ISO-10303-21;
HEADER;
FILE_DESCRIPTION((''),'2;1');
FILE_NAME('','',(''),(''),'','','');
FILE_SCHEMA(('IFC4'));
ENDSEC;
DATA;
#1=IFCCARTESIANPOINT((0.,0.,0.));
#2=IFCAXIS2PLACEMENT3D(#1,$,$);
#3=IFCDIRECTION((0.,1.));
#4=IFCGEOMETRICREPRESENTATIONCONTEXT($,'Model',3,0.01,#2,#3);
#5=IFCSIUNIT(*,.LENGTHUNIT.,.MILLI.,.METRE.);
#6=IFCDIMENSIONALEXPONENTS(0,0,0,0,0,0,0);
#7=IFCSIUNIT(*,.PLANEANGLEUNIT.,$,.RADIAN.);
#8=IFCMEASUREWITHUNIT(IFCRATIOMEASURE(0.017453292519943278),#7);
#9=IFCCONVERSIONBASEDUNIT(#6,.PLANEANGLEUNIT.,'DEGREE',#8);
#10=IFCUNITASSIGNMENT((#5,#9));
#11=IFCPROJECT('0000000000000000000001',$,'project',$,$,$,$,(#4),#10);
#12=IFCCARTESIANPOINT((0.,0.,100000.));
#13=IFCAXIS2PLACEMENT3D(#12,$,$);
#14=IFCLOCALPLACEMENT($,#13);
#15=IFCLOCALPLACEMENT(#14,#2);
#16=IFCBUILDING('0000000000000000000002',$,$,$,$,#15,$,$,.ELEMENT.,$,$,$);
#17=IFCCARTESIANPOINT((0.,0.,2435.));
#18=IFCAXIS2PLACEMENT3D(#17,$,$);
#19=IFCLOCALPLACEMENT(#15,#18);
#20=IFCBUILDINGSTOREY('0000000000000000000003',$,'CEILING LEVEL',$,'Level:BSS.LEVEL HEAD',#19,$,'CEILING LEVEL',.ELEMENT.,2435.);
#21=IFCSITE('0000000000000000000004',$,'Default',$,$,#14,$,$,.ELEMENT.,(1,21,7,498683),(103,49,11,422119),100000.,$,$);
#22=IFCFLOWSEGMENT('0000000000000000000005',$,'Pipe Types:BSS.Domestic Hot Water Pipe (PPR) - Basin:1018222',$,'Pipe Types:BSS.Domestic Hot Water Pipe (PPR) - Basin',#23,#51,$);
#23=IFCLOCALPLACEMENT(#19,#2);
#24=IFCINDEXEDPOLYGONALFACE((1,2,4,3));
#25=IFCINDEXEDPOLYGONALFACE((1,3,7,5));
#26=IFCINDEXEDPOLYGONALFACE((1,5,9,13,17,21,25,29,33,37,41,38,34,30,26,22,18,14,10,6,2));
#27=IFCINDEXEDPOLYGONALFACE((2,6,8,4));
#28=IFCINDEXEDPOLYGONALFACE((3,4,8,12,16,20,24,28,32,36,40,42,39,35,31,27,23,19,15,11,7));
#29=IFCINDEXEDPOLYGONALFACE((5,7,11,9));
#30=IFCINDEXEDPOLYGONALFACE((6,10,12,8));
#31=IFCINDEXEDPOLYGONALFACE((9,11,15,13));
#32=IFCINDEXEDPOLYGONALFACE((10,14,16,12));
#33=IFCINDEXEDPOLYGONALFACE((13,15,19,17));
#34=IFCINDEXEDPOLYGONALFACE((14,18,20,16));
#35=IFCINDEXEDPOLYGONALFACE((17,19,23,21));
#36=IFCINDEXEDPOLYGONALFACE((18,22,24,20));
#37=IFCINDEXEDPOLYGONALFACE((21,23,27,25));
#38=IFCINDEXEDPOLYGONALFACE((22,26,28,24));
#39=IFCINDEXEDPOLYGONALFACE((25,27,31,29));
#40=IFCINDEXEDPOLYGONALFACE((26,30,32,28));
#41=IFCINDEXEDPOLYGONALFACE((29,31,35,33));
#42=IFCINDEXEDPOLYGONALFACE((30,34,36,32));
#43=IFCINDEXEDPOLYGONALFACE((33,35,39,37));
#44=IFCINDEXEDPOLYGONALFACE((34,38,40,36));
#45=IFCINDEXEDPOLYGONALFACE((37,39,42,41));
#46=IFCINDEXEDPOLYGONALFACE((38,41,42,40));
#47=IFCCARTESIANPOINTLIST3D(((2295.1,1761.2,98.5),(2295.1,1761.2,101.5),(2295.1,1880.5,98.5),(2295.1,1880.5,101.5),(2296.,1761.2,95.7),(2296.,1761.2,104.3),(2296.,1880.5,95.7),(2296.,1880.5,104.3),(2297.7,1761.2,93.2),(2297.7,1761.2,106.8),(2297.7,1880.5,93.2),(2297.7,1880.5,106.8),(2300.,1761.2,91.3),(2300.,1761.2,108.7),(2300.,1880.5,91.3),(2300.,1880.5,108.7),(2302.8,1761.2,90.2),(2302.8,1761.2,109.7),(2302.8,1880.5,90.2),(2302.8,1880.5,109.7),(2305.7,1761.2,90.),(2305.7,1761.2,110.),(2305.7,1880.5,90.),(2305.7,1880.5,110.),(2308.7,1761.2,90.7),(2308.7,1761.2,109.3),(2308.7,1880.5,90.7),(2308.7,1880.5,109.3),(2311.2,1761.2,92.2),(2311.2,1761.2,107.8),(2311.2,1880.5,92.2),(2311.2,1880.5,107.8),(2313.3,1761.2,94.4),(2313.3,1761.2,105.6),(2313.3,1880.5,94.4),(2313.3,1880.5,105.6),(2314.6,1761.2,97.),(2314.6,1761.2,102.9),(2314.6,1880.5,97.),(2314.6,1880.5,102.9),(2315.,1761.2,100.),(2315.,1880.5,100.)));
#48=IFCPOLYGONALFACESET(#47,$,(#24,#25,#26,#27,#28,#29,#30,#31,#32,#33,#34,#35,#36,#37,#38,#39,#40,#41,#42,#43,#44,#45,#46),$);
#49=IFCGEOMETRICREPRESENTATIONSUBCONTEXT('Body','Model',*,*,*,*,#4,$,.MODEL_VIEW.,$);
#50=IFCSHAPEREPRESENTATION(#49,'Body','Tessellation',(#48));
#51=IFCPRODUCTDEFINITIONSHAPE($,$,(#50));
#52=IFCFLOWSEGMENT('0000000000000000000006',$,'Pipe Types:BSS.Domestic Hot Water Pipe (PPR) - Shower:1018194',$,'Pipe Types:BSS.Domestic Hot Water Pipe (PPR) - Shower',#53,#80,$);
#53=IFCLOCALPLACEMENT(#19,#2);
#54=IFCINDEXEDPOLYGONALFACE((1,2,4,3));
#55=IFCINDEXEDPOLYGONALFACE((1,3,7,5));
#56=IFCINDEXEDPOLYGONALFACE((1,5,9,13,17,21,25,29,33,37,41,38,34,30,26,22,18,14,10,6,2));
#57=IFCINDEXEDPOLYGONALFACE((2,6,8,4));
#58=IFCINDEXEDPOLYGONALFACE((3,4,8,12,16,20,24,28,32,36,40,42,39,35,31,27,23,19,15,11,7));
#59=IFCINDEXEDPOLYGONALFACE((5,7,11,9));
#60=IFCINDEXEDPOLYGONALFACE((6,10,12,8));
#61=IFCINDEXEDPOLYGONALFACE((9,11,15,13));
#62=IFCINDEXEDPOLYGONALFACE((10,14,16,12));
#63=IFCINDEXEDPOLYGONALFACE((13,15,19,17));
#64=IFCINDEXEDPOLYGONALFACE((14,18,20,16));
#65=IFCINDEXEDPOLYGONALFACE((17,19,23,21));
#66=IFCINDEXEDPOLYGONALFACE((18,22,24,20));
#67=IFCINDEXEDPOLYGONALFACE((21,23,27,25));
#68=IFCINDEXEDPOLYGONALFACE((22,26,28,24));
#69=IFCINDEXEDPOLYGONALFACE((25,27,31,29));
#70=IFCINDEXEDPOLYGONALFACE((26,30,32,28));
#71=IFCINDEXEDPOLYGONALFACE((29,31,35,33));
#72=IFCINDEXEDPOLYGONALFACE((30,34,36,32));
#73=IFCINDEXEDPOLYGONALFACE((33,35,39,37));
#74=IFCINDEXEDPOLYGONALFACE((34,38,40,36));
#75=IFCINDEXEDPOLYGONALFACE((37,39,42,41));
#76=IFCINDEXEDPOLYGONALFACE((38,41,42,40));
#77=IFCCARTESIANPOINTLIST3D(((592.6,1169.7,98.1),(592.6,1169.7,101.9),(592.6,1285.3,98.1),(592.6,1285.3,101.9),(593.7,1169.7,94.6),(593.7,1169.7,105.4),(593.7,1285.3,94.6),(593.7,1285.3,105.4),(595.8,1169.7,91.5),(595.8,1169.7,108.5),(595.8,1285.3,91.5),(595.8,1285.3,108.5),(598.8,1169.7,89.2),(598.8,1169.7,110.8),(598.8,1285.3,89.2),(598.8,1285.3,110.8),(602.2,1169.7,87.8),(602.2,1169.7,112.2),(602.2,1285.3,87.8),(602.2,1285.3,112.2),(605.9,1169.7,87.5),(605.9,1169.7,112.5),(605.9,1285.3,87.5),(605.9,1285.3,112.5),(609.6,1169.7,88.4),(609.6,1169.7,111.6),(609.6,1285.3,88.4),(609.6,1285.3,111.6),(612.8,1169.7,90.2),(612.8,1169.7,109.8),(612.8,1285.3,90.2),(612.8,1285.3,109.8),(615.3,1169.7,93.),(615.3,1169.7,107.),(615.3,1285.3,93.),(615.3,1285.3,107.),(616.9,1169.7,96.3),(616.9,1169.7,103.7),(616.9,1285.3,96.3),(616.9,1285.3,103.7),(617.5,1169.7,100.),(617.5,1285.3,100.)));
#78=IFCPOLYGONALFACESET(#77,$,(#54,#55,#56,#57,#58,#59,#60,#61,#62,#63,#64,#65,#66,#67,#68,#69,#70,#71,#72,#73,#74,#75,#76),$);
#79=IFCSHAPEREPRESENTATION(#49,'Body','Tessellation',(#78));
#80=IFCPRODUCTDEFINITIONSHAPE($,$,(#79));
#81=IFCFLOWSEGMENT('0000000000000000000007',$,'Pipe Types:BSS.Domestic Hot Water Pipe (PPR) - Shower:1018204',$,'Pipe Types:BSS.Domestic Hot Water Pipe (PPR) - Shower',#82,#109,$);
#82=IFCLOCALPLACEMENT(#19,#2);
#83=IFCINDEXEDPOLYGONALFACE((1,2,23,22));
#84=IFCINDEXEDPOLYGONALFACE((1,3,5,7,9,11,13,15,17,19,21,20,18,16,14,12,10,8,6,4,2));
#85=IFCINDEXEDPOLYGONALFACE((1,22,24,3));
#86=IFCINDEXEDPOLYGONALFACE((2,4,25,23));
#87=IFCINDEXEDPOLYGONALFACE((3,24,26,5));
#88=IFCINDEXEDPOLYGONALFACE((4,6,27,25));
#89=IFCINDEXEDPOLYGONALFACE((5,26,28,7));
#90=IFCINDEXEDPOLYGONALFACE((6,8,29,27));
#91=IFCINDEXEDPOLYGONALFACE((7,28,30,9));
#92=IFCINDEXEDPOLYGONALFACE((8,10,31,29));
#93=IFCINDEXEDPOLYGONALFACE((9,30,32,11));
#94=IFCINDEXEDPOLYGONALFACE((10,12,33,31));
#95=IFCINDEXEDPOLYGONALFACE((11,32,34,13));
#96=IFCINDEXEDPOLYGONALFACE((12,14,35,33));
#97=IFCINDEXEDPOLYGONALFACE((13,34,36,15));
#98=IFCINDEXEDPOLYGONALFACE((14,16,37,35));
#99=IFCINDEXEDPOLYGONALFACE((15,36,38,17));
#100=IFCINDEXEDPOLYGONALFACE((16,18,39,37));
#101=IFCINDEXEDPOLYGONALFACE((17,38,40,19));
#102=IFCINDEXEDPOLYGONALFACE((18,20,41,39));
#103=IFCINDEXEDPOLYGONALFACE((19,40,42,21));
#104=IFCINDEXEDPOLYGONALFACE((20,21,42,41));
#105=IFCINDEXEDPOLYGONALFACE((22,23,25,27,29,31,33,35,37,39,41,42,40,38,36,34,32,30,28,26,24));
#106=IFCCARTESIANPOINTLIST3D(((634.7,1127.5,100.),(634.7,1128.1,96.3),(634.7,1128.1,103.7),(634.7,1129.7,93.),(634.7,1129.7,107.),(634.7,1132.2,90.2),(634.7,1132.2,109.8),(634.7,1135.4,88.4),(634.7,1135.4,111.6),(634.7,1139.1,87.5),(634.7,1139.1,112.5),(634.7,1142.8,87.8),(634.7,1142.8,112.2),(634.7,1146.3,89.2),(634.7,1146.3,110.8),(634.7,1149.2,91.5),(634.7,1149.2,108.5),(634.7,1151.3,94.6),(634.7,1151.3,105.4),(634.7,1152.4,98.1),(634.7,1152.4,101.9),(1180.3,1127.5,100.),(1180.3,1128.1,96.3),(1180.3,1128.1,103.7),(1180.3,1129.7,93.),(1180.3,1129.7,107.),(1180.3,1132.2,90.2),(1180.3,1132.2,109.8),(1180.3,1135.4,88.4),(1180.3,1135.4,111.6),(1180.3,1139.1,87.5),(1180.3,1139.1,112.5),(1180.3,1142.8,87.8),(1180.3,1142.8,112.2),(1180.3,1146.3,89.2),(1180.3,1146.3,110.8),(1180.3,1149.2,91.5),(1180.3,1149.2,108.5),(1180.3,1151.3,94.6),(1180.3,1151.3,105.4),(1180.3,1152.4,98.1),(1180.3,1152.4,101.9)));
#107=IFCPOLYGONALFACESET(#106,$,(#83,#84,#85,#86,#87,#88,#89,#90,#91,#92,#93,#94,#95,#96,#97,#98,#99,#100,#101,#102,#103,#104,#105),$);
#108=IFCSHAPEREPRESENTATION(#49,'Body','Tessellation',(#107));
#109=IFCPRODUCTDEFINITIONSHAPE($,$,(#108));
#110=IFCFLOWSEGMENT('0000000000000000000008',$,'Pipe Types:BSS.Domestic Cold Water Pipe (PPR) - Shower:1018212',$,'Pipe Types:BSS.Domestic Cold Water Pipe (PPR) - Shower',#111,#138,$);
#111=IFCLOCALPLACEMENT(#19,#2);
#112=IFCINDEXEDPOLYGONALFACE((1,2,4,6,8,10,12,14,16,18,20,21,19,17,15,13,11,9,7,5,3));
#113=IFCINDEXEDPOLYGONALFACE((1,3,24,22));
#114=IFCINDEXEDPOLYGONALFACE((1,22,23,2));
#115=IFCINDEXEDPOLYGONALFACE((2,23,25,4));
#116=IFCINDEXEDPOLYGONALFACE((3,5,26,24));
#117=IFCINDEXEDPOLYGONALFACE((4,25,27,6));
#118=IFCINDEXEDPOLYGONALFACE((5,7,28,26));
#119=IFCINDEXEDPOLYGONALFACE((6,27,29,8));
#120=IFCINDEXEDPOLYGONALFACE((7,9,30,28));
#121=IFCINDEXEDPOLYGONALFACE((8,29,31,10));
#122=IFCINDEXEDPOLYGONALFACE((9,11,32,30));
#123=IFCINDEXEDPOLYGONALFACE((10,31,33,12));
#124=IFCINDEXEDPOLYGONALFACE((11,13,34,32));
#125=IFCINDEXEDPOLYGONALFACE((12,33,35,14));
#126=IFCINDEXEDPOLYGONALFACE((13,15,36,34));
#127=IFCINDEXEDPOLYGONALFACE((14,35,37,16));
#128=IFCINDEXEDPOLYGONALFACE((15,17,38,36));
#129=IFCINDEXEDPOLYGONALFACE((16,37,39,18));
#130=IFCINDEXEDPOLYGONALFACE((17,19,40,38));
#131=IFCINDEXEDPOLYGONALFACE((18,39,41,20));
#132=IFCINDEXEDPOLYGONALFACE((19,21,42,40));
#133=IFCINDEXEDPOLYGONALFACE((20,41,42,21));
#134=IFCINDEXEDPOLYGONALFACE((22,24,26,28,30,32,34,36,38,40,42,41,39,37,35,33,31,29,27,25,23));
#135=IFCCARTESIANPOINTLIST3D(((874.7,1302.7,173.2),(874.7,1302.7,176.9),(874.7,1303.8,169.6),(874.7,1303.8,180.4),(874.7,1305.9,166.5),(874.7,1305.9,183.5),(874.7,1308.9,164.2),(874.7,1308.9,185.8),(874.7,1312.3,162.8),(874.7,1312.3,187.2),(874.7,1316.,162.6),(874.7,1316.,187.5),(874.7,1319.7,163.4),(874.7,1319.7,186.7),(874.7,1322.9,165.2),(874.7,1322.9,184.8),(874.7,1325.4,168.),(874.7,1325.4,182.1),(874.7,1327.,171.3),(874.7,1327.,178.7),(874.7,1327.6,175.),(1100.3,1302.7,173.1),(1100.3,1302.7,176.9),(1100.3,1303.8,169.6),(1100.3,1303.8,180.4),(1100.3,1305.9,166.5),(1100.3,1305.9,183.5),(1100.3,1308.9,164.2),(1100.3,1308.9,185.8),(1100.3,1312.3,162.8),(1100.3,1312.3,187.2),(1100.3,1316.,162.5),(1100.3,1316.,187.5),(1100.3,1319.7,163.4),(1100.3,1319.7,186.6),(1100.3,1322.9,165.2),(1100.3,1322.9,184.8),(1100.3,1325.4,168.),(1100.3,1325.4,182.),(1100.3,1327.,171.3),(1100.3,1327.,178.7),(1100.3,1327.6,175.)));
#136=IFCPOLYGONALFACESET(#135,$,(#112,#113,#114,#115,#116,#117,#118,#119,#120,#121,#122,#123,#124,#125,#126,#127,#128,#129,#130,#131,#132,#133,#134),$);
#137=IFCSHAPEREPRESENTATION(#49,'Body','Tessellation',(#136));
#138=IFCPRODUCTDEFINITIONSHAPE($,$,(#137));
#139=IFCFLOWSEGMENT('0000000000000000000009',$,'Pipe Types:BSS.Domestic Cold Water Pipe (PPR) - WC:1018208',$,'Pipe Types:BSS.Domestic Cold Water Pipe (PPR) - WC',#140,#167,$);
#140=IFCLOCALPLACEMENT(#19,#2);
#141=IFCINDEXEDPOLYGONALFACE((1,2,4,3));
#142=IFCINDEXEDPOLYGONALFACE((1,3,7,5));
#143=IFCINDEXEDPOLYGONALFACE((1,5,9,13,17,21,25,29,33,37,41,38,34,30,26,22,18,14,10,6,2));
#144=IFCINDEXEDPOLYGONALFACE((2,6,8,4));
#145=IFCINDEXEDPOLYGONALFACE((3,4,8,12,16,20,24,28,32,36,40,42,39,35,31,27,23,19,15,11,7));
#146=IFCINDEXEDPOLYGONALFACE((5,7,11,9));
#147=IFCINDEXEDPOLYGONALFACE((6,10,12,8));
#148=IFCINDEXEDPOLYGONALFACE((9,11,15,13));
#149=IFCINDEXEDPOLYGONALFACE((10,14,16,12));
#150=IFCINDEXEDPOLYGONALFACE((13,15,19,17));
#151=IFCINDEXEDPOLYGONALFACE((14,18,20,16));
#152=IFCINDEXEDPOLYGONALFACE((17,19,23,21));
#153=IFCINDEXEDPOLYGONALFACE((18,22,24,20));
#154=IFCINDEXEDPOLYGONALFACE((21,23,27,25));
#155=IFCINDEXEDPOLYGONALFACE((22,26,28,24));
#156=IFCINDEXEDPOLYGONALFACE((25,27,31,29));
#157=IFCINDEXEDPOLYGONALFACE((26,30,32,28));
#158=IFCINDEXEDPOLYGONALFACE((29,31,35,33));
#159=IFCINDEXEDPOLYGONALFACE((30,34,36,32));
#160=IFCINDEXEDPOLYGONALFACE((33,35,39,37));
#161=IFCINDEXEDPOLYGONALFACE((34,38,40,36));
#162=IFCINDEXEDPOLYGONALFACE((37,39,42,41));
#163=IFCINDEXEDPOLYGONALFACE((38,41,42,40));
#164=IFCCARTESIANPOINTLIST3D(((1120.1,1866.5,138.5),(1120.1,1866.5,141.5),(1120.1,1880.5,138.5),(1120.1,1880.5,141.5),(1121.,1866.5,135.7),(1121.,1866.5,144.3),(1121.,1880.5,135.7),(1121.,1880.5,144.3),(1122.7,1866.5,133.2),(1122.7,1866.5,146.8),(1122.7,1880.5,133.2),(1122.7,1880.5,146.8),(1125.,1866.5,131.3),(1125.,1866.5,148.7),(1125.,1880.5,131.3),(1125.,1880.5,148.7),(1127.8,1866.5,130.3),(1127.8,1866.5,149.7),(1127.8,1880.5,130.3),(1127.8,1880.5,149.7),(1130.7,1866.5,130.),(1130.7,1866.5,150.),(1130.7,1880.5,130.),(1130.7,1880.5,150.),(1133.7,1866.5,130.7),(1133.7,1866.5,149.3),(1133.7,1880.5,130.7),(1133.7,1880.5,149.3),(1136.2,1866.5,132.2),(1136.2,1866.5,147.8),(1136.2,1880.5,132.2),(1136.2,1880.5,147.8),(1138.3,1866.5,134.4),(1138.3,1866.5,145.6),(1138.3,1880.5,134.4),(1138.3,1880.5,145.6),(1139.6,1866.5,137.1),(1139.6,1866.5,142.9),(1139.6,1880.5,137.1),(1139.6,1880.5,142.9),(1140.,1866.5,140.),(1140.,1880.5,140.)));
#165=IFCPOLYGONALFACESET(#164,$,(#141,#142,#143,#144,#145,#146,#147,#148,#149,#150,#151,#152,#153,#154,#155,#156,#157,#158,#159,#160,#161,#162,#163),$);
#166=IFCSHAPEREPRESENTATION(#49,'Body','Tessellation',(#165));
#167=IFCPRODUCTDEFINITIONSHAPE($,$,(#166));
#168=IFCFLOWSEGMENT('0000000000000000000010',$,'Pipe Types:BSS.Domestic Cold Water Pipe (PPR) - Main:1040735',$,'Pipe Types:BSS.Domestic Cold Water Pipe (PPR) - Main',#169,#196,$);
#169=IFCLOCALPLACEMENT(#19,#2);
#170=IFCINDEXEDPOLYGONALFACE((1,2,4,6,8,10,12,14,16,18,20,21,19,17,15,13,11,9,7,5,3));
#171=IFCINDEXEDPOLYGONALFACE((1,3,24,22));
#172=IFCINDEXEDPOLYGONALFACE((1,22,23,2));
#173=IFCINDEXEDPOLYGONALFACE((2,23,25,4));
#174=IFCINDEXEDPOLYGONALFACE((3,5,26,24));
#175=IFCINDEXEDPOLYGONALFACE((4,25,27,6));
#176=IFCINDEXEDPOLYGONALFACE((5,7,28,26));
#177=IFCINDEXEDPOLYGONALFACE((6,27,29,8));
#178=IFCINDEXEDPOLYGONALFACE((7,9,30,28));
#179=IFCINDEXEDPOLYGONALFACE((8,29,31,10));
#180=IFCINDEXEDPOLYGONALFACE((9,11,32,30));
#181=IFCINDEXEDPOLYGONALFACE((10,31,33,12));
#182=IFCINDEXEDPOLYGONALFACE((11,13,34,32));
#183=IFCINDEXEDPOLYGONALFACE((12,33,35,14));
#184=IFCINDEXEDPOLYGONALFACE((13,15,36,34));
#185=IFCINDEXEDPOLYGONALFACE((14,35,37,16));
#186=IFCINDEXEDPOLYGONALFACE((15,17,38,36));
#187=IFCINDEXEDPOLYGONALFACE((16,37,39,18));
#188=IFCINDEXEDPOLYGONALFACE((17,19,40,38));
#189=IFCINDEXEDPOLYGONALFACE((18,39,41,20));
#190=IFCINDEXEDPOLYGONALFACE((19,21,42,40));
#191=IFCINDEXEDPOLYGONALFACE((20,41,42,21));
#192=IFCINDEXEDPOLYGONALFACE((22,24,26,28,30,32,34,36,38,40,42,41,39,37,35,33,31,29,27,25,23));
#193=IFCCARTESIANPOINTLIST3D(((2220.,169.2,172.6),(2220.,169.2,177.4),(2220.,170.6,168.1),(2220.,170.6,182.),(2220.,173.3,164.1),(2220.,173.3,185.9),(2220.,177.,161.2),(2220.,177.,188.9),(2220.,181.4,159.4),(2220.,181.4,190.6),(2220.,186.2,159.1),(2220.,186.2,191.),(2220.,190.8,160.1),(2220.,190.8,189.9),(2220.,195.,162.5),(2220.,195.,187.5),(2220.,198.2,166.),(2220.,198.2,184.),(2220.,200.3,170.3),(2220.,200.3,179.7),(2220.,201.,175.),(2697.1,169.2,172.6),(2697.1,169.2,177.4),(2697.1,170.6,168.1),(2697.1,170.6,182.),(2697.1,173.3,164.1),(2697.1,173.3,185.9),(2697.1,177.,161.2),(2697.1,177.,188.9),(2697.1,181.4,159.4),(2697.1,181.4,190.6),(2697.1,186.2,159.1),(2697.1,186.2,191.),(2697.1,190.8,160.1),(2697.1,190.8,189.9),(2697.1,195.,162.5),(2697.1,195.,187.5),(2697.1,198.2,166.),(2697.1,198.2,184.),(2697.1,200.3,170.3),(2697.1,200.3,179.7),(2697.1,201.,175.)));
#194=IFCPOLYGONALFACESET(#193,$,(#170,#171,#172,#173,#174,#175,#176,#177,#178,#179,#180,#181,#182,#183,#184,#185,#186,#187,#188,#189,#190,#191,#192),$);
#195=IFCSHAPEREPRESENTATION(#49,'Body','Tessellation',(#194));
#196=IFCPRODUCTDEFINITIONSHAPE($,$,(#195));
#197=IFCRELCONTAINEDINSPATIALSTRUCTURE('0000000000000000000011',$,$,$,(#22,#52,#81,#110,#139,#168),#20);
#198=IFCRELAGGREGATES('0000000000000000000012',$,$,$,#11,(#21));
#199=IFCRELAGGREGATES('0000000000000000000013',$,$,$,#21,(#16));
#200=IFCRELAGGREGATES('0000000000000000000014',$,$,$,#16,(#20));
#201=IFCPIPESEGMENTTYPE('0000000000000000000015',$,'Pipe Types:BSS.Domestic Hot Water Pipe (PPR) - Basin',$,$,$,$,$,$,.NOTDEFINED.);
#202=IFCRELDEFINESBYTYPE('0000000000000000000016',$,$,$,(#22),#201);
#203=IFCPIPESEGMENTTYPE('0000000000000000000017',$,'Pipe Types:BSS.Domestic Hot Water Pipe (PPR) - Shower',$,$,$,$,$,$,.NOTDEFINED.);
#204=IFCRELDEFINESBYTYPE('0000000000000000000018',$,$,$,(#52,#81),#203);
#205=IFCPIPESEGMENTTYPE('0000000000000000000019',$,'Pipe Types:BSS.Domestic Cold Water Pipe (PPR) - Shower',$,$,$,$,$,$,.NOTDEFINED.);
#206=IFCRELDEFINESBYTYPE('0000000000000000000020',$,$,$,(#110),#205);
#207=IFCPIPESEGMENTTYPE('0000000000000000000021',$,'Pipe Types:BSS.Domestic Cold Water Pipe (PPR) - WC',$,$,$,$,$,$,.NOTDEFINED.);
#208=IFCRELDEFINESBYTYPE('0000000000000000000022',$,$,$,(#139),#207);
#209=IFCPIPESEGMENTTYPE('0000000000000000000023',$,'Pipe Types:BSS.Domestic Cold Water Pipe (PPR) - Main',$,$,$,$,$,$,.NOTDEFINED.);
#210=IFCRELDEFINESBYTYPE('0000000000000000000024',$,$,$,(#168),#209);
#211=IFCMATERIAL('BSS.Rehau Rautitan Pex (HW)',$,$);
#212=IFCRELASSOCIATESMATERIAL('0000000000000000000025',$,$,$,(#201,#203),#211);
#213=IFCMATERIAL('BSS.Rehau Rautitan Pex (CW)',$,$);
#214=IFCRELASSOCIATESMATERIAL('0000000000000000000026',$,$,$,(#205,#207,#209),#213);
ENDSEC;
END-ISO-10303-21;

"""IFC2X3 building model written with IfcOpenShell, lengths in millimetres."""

from ifc_helpers import new_model, entity, si_unit, converted_unit, direction, frame, frame_2d, origin, origin_2d_with_axis, place, context, subcontext, project, spatial, circle, extrude, material, type_object, element, save


model = new_model("IFC2X3")

# Units and contexts
model_context = context("Model", 3, precision=0.01, world=origin(), true_north=direction((0.0, 1.0)))
body_context = subcontext(model_context, "Body", "Model", "MODEL_VIEW")
ifc_project = project(units=[si_unit("LENGTHUNIT", "METRE", prefix="MILLI"), converted_unit("PLANEANGLEUNIT", "DEGREE", entity("IfcRatioMeasure", 0.017453292519943278), si_unit("PLANEANGLEUNIT", "RADIAN"), dimensions=[0, 0, 0, 0, 0, 0, 0])], contexts=[model_context])

# Site, building, storey
site_placement = place(None, frame((0.0, 0.0, 100000.0)))
site = spatial("IfcSite", under=ifc_project, at=site_placement, Name="Default", CompositionType="ELEMENT", RefLatitude=(1, 21, 7, 498683), RefLongitude=(103, 49, 11, 422119), RefElevation=100000.0)
building_placement = place(site_placement, origin())
building = spatial("IfcBuilding", under=site, at=building_placement, CompositionType="ELEMENT")
storey_placement = place(building_placement, frame((0.0, 0.0, 2435.0)))
storey = spatial("IfcBuildingStorey", under=building, at=storey_placement, Name="CEILING LEVEL", ObjectType="Level:BSS.LEVEL HEAD", LongName="CEILING LEVEL", CompositionType="ELEMENT", Elevation=2435.0)

# Flow segments
ifc_material_1 = material(Name="BSS.Rehau Rautitan Pex (HW)")
pipe_segment_type_1 = type_object("IfcPipeSegmentType", Name="Pipe Types:BSS.Domestic Hot Water Pipe (PPR) - Basin", PredefinedType="NOTDEFINED", material=ifc_material_1)
flow_segment_1_placement = place(storey_placement, origin())
element("IfcFlowSegment", 1, at=flow_segment_1_placement, inside=storey, type_object=pipe_segment_type_1, Name="Pipe Types:BSS.Domestic Hot Water Pipe (PPR) - Basin:1018222", ObjectType="Pipe Types:BSS.Domestic Hot Water Pipe (PPR) - Basin", context=body_context, shape_type="SweptSolid", body=[
    extrude(circle(Radius=10.0, at=frame_2d((0.0, 0.0), x_axis=(1.0, 0.0))), frame((2305.0, 1880.5, 100.0), z_axis=(0.00001, -1.0, 0.0), x_axis=(1.0, 0.00001, 0.0)), (0.0, 0.0, 1.0), 119.3),
])
pipe_segment_type_2 = type_object("IfcPipeSegmentType", Name="Pipe Types:BSS.Domestic Hot Water Pipe (PPR) - Shower", PredefinedType="NOTDEFINED", material=ifc_material_1)
flow_segment_2_placement = place(storey_placement, origin())
element("IfcFlowSegment", 2, at=flow_segment_2_placement, inside=storey, type_object=pipe_segment_type_2, Name="Pipe Types:BSS.Domestic Hot Water Pipe (PPR) - Shower:1018194", ObjectType="Pipe Types:BSS.Domestic Hot Water Pipe (PPR) - Shower", context=body_context, shape_type="SweptSolid", body=[
    extrude(circle(Radius=12.5, at=frame_2d((0.0, 0.0), x_axis=(1.0, 0.0))), frame((605.0, 1285.3, 100.0), z_axis=(0.0, -1.0, 0.000036), x_axis=(1.0, 0.0, 0.0)), (0.0, 0.0, 1.0), 115.6),
])
flow_segment_3_placement = place(storey_placement, origin())
element("IfcFlowSegment", 3, at=flow_segment_3_placement, inside=storey, type_object=pipe_segment_type_2, Name="Pipe Types:BSS.Domestic Hot Water Pipe (PPR) - Shower:1018204", ObjectType="Pipe Types:BSS.Domestic Hot Water Pipe (PPR) - Shower", context=body_context, shape_type="SweptSolid", body=[
    extrude(circle(Radius=12.5, at=frame_2d((0.0, 0.0), x_axis=(1.0, 0.0))), frame((634.7, 1140.0, 100.0), z_axis=(1.0, 0.0, -0.00001), x_axis=(0.0, -1.0, 0.0)), (0.0, 0.0, 1.0), 545.6),
])
ifc_material_2 = material(Name="BSS.Rehau Rautitan Pex (CW)")
pipe_segment_type_3 = type_object("IfcPipeSegmentType", Name="Pipe Types:BSS.Domestic Cold Water Pipe (PPR) - Shower", PredefinedType="NOTDEFINED", material=ifc_material_2)
flow_segment_4_placement = place(storey_placement, origin())
element("IfcFlowSegment", 4, at=flow_segment_4_placement, inside=storey, type_object=pipe_segment_type_3, Name="Pipe Types:BSS.Domestic Cold Water Pipe (PPR) - Shower:1018212", ObjectType="Pipe Types:BSS.Domestic Cold Water Pipe (PPR) - Shower", context=body_context, shape_type="SweptSolid", body=[
    extrude(circle(Radius=12.5, at=origin_2d_with_axis()), frame((874.7, 1315.1, 175.0), z_axis=(1.0, 0.000003, -0.000078), x_axis=(-0.000003, 1.0, 0.0)), (0.0, 0.0, 1.0), 225.6),
])
pipe_segment_type_4 = type_object("IfcPipeSegmentType", Name="Pipe Types:BSS.Domestic Cold Water Pipe (PPR) - WC", PredefinedType="NOTDEFINED", material=ifc_material_2)
flow_segment_5_placement = place(storey_placement, origin())
element("IfcFlowSegment", 5, at=flow_segment_5_placement, inside=storey, type_object=pipe_segment_type_4, Name="Pipe Types:BSS.Domestic Cold Water Pipe (PPR) - WC:1018208", ObjectType="Pipe Types:BSS.Domestic Cold Water Pipe (PPR) - WC", context=body_context, shape_type="SweptSolid", body=[
    extrude(circle(Radius=10.0, at=frame_2d((0.0, 0.0), x_axis=(1.0, 0.0))), frame((1130.0, 1866.5, 140.0), z_axis=(-0.000042, 1.0, 0.0), x_axis=(1.0, 0.000042, 0.0)), (0.0, 0.0, 1.0), 14.0),
])
pipe_segment_type_5 = type_object("IfcPipeSegmentType", Name="Pipe Types:BSS.Domestic Cold Water Pipe (PPR) - Main", PredefinedType="NOTDEFINED", material=ifc_material_2)
flow_segment_6_placement = place(storey_placement, origin())
element("IfcFlowSegment", 6, at=flow_segment_6_placement, inside=storey, type_object=pipe_segment_type_5, Name="Pipe Types:BSS.Domestic Cold Water Pipe (PPR) - Main:1040735", ObjectType="Pipe Types:BSS.Domestic Cold Water Pipe (PPR) - Main", context=body_context, shape_type="SweptSolid", body=[
    extrude(circle(Radius=16.0, at=origin_2d_with_axis()), frame((2220.0, 185.0, 175.0), z_axis=(1.0, 0.0, 0.0), x_axis=(0.0, 1.0, 0.0)), (0.0, 0.0, 1.0), 477.1),
])

save(model, "model.ifc")
